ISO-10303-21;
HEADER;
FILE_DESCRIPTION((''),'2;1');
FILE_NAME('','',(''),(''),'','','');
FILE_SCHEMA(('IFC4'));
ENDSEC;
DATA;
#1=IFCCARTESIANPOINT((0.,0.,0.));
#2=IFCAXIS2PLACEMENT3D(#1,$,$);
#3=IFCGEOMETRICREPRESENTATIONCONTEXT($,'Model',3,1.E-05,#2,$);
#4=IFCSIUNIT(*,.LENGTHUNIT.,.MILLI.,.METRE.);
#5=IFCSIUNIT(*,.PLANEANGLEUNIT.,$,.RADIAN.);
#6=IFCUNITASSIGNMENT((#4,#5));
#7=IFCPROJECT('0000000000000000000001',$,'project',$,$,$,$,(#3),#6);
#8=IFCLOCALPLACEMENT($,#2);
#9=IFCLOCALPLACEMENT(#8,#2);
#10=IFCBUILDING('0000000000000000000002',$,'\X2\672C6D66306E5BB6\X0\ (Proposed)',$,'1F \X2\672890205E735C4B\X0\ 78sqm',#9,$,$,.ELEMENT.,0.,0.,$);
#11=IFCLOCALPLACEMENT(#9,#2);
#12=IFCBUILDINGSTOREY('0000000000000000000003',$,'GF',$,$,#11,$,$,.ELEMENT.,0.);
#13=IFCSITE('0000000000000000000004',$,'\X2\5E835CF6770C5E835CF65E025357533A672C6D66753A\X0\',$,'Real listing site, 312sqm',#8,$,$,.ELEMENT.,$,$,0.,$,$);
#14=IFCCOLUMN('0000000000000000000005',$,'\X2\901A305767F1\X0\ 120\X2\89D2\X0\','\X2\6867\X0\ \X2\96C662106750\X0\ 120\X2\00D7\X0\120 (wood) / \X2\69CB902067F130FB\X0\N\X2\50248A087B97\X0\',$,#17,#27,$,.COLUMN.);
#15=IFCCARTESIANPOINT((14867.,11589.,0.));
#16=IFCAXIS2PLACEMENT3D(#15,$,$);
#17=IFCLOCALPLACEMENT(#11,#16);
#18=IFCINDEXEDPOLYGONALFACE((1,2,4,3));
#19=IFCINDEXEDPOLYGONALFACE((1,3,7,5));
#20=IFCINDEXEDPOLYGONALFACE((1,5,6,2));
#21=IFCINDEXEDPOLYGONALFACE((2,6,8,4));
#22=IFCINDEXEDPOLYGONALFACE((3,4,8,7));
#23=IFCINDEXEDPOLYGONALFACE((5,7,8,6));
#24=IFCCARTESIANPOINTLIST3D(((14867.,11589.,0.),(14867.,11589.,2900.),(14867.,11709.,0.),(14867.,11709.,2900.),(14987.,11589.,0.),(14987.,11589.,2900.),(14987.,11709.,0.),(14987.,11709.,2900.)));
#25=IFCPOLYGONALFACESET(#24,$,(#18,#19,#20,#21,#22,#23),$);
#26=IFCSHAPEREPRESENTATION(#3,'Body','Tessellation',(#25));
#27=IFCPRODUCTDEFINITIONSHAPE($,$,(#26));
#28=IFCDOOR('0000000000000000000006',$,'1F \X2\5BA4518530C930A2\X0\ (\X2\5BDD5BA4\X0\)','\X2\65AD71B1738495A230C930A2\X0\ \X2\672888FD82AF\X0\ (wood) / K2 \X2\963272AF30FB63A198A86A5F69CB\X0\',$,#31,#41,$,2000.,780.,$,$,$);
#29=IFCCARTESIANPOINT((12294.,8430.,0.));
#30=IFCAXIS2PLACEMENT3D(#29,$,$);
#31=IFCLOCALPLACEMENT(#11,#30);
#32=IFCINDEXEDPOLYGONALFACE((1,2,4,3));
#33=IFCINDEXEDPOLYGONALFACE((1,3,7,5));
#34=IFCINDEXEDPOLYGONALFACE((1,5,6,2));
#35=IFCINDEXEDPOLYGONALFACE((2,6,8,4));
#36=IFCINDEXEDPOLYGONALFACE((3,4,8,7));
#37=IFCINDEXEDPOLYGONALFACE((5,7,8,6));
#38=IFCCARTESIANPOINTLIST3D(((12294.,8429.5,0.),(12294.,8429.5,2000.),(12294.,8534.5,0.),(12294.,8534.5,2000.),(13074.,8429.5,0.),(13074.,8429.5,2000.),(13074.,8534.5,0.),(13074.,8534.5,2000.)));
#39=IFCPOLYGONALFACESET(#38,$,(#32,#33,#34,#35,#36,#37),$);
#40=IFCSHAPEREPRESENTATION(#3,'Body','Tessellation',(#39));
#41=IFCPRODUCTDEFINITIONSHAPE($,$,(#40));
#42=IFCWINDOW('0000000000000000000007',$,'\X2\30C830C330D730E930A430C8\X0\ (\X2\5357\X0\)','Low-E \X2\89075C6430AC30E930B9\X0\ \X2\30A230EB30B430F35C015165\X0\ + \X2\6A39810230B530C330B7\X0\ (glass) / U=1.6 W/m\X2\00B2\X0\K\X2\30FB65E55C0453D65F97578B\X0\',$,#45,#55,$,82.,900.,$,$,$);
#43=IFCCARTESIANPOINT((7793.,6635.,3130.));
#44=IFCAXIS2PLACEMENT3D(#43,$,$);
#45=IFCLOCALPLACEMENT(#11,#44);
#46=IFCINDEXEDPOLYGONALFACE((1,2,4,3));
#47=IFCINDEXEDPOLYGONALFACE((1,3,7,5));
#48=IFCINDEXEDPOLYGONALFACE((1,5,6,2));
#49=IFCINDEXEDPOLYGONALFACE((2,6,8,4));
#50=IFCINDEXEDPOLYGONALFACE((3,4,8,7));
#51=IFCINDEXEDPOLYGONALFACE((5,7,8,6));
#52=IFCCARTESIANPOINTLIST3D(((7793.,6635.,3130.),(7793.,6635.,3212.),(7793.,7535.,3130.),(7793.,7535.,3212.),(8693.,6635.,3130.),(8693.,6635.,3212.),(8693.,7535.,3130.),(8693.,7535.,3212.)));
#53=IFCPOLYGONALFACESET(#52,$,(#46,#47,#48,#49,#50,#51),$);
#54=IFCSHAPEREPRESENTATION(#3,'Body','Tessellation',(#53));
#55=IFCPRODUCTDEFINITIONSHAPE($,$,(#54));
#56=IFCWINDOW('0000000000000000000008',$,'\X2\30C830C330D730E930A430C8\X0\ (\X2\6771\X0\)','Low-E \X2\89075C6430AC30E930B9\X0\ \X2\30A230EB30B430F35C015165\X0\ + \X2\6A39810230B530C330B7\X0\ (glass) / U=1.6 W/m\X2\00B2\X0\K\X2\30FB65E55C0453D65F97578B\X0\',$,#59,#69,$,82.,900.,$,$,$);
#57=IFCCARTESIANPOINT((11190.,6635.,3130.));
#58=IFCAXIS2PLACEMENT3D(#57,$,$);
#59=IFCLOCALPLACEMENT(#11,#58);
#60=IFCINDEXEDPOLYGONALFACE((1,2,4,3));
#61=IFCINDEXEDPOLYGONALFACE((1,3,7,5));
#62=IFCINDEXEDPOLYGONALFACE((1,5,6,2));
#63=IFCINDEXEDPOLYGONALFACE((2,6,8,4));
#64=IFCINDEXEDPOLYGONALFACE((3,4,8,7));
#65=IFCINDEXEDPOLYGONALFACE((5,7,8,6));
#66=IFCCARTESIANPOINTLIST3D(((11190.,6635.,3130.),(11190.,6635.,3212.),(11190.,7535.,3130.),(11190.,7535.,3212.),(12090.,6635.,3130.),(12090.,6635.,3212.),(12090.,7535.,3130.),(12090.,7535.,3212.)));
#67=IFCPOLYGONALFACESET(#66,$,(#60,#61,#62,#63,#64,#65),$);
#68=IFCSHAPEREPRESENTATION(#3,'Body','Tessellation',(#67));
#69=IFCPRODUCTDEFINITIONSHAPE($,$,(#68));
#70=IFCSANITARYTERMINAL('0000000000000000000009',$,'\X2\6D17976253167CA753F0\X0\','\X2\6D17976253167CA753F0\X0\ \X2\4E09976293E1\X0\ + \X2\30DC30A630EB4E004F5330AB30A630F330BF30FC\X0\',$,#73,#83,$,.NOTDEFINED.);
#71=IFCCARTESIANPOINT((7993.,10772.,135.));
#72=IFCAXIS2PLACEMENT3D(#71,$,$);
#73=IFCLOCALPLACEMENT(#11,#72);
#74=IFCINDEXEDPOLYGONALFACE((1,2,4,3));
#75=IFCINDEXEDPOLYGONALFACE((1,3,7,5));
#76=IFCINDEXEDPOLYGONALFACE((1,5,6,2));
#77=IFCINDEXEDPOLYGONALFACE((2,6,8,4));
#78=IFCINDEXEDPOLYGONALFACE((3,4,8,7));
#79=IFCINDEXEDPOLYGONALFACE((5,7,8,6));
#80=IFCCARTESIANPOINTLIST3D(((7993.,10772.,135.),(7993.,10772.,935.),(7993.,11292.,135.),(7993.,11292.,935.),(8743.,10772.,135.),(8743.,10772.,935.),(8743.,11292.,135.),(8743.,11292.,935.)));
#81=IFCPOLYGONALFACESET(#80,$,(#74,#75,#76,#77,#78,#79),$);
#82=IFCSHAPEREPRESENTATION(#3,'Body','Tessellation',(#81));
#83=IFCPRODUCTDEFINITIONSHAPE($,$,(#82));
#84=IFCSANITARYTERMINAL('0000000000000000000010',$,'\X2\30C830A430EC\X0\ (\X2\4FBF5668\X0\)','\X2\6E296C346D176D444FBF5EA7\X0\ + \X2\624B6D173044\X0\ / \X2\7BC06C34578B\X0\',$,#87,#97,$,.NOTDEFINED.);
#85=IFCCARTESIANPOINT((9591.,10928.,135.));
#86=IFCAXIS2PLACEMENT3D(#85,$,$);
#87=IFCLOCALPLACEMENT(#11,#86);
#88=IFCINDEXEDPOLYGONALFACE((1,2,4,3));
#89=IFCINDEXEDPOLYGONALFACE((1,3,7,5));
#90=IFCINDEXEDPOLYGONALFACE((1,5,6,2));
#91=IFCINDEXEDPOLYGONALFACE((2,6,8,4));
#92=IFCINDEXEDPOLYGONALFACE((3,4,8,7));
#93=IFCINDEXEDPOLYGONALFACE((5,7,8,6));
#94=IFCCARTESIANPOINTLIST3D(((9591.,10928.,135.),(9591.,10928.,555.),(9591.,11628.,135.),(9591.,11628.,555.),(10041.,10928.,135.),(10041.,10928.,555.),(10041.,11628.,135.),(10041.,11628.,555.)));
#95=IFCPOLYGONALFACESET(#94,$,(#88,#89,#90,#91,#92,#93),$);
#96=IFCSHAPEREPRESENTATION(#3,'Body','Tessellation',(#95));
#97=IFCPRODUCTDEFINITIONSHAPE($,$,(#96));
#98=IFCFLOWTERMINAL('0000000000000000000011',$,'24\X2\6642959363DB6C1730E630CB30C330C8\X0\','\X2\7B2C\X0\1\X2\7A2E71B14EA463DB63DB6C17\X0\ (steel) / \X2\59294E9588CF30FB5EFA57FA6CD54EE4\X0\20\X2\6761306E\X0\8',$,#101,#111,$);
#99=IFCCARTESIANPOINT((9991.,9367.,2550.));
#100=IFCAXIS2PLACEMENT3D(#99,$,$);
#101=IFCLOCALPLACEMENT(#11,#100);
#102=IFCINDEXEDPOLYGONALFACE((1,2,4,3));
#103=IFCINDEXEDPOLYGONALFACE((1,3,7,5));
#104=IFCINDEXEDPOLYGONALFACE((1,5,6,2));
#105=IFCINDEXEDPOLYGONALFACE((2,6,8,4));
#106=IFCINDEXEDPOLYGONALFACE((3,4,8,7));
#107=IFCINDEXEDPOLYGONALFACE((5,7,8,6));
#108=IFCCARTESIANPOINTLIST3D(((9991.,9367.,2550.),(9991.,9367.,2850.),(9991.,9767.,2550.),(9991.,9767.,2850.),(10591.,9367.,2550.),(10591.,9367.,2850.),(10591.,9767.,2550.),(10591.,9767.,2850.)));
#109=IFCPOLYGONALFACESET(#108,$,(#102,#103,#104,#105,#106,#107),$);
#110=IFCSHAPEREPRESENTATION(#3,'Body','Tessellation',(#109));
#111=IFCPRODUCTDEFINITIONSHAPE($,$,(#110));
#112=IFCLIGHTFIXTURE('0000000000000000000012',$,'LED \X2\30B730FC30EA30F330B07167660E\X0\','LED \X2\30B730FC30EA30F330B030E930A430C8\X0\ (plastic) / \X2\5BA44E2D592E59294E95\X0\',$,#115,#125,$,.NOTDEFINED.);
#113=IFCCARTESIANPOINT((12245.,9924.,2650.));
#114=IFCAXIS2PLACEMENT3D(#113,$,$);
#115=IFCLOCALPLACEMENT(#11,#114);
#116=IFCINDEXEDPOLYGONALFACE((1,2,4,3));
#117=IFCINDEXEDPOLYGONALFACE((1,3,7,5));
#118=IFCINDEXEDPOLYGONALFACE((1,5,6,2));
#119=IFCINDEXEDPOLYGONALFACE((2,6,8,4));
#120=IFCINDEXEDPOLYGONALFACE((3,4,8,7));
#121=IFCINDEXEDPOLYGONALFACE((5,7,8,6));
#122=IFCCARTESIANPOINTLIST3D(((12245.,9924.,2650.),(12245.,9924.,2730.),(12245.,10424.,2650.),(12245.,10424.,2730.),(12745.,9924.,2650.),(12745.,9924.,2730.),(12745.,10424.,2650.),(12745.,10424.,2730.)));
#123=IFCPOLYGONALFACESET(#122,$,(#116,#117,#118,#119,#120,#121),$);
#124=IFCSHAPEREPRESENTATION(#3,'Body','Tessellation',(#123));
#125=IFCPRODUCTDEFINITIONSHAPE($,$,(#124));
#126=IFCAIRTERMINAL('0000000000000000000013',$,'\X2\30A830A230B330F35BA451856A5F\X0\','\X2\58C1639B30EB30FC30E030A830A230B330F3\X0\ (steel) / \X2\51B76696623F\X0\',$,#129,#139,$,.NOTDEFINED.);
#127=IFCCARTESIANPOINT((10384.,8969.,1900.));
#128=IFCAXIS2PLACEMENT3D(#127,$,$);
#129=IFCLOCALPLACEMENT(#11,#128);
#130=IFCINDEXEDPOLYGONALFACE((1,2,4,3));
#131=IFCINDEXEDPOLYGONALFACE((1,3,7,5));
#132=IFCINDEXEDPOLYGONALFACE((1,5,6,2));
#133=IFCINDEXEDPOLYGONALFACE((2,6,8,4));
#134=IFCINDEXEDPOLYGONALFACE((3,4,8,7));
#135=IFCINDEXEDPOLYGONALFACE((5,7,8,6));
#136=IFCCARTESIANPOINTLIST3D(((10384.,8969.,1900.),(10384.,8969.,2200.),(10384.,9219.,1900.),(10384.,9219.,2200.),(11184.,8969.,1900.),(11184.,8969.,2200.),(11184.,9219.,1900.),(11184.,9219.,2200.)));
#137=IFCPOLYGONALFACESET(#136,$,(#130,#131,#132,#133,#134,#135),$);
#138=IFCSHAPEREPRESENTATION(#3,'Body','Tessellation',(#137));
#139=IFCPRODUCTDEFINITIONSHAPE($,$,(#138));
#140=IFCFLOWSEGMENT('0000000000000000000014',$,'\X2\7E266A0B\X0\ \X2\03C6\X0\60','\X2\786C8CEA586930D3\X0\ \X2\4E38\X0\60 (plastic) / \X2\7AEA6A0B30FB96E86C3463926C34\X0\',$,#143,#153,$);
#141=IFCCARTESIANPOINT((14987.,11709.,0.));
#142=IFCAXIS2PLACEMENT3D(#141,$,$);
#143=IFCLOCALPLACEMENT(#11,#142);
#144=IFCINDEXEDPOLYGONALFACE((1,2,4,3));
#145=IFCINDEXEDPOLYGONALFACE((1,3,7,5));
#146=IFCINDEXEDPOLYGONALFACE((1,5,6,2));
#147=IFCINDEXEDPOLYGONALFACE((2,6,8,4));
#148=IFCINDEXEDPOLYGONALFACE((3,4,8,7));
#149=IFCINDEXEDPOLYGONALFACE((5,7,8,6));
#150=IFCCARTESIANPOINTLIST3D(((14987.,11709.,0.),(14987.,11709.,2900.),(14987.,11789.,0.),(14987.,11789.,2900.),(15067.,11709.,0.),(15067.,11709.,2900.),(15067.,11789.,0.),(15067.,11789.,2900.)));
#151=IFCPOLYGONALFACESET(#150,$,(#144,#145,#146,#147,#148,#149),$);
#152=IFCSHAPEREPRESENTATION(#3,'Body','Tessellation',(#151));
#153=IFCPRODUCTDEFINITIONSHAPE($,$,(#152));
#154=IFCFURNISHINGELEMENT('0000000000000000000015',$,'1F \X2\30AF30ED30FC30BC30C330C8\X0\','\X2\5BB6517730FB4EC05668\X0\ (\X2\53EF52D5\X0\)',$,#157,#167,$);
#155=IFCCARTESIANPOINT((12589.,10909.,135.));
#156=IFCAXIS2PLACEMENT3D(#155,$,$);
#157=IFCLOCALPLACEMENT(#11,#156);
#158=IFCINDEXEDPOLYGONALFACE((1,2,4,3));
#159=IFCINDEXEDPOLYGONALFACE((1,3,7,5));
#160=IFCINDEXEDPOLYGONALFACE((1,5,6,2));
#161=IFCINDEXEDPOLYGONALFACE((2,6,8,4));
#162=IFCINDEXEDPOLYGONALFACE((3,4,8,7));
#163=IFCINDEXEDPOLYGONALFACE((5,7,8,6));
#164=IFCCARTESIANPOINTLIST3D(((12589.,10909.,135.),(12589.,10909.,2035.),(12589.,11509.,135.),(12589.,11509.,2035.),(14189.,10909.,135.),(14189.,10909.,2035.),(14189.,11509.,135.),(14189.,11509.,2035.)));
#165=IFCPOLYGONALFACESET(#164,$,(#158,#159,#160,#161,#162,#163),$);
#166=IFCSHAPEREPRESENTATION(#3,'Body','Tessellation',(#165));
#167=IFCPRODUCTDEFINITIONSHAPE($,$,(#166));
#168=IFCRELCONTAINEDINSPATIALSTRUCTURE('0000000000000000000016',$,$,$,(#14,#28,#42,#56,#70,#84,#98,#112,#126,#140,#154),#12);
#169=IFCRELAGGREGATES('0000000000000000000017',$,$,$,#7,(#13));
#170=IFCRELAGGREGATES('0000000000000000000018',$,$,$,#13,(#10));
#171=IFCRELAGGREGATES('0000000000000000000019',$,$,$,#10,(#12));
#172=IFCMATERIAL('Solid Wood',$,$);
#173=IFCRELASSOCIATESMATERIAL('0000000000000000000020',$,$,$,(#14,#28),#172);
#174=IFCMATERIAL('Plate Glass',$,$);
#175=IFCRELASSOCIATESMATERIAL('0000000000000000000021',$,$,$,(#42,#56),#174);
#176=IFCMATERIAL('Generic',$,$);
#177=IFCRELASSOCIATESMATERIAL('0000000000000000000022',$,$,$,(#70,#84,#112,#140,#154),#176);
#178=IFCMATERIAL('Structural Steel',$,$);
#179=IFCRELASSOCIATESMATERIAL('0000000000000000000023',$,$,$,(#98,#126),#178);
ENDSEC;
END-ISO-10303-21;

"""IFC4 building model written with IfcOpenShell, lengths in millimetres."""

from ifc_helpers import new_model, si_unit, frame, frame_2d, origin, place, context, project, spatial, rectangle, extrude, material, element, save


model = new_model("IFC4")

# Units and contexts
model_context = context("Model", 3, precision=1e-05, world=origin())
ifc_project = project(units=[si_unit("LENGTHUNIT", "METRE", prefix="MILLI"), si_unit("PLANEANGLEUNIT", "RADIAN")], contexts=[model_context])

# Site, building, storey
site_placement = place(None, origin())
site = spatial("IfcSite", under=ifc_project, at=site_placement, Name="広島県広島市南区本浦町", ObjectType="Real listing site, 312sqm", CompositionType="ELEMENT", RefElevation=0.0)
building_placement = place(site_placement, origin())
building = spatial("IfcBuilding", under=site, at=building_placement, Name="本浦の家 (Proposed)", ObjectType="1F 木造平屋 78sqm", CompositionType="ELEMENT", ElevationOfRefHeight=0.0, ElevationOfTerrain=0.0)
storey_placement = place(building_placement, origin())
storey = spatial("IfcBuildingStorey", under=building, at=storey_placement, Name="GF", CompositionType="ELEMENT", Elevation=0.0)

# Column
ifc_material_1 = material(Name="Solid Wood")
column_1_placement = place(storey_placement, frame((14867.0, 11589.0, 0.0)))
element("IfcColumn", 1, at=column_1_placement, inside=storey, material=ifc_material_1, Name="通し柱 120角", Description="桧 集成材 120×120 (wood) / 構造柱・N値計算", PredefinedType="COLUMN", context=model_context, shape_type="SweptSolid", body=[
    extrude(rectangle(XDim=120.0, YDim=120.0, at=frame_2d((60.0, 60.0))), frame((14867.0, 11589.0, 0.0)), (0.0, 0.0, 1.0), 2900.0),
])

# Door
door_placement = place(storey_placement, frame((12294.0, 8430.0, 0.0)))
element("IfcDoor", 2, at=door_placement, inside=storey, material=ifc_material_1, Name="1F 室内ドア (寝室)", Description="断熱玄関ドア 木製芯 (wood) / K2 防犯・採風機構", OverallHeight=2000.0, OverallWidth=780.0, context=model_context, shape_type="SweptSolid", body=[
    extrude(rectangle(XDim=780.0, YDim=105.0, at=frame_2d((390.0, 52.0))), frame((12294.0, 8430.0, 0.0)), (0.0, 0.0, 1.0), 2000.0),
])

# Windows
ifc_material_2 = material(Name="Plate Glass")
window_1_placement = place(storey_placement, frame((7793.0, 6635.0, 3130.0)))
element("IfcWindow", 3, at=window_1_placement, inside=storey, material=ifc_material_2, Name="トップライト (南)", Description="Low-E 複層ガラス アルゴン封入 + 樹脂サッシ (glass) / U=1.6 W/m²K・日射取得型", OverallHeight=82.0, OverallWidth=900.0, context=model_context, shape_type="SweptSolid", body=[
    extrude(rectangle(XDim=900.0, YDim=900.0, at=frame_2d((450.0, 450.0))), frame((7793.0, 6635.0, 3130.0)), (0.0, 0.0, 1.0), 82.0),
])
window_2_placement = place(storey_placement, frame((11190.0, 6635.0, 3130.0)))
element("IfcWindow", 4, at=window_2_placement, inside=storey, material=ifc_material_2, Name="トップライト (東)", Description="Low-E 複層ガラス アルゴン封入 + 樹脂サッシ (glass) / U=1.6 W/m²K・日射取得型", OverallHeight=82.0, OverallWidth=900.0, context=model_context, shape_type="SweptSolid", body=[
    extrude(rectangle(XDim=900.0, YDim=900.0, at=frame_2d((450.0, 450.0))), frame((11190.0, 6635.0, 3130.0)), (0.0, 0.0, 1.0), 82.0),
])

# Sanitary terminals
ifc_material_3 = material(Name="Generic")
sanitary_terminal_1_placement = place(storey_placement, frame((7993.0, 10772.0, 135.0)))
element("IfcSanitaryTerminal", 5, at=sanitary_terminal_1_placement, inside=storey, material=ifc_material_3, Name="洗面化粧台", Description="洗面化粧台 三面鏡 + ボウル一体カウンター", PredefinedType="NOTDEFINED", context=model_context, shape_type="SweptSolid", body=[
    extrude(rectangle(XDim=750.0, YDim=520.0, at=frame_2d((375.0, 260.0))), frame((7993.0, 10772.0, 135.0)), (0.0, 0.0, 1.0), 800.0),
])
sanitary_terminal_2_placement = place(storey_placement, frame((9591.0, 10928.0, 135.0)))
element("IfcSanitaryTerminal", 6, at=sanitary_terminal_2_placement, inside=storey, material=ifc_material_3, Name="トイレ (便器)", Description="温水洗浄便座 + 手洗い / 節水型", PredefinedType="NOTDEFINED", context=model_context, shape_type="SweptSolid", body=[
    extrude(rectangle(XDim=450.0, YDim=700.0, at=frame_2d((225.0, 350.0))), frame((9591.0, 10928.0, 135.0)), (0.0, 0.0, 1.0), 420.0),
])

# Flow terminal
ifc_material_4 = material(Name="Structural Steel")
flow_terminal_placement = place(storey_placement, frame((9991.0, 9367.0, 2550.0)))
element("IfcFlowTerminal", 7, at=flow_terminal_placement, inside=storey, material=ifc_material_4, Name="24時間換気ユニット", Description="第1種熱交換換気 (steel) / 天井裏・建基法令20条の8", context=model_context, shape_type="SweptSolid", body=[
    extrude(rectangle(XDim=600.0, YDim=400.0, at=frame_2d((300.0, 200.0))), frame((9991.0, 9367.0, 2550.0)), (0.0, 0.0, 1.0), 300.0),
])

# Light fixture
light_fixture_placement = place(storey_placement, frame((12245.0, 9924.0, 2650.0)))
element("IfcLightFixture", 8, at=light_fixture_placement, inside=storey, material=ifc_material_3, Name="LED シーリング照明", Description="LED シーリングライト (plastic) / 室中央天井", PredefinedType="NOTDEFINED", context=model_context, shape_type="SweptSolid", body=[
    extrude(rectangle(XDim=500.0, YDim=500.0, at=frame_2d((250.0, 250.0))), frame((12245.0, 9924.0, 2650.0)), (0.0, 0.0, 1.0), 80.0),
])

# Air terminal
air_terminal_placement = place(storey_placement, frame((10384.0, 8969.0, 1900.0)))
element("IfcAirTerminal", 9, at=air_terminal_placement, inside=storey, material=ifc_material_4, Name="エアコン室内機", Description="壁掛ルームエアコン (steel) / 冷暖房", PredefinedType="NOTDEFINED", context=model_context, shape_type="SweptSolid", body=[
    extrude(rectangle(XDim=800.0, YDim=250.0, at=frame_2d((400.0, 125.0))), frame((10384.0, 8969.0, 1900.0)), (0.0, 0.0, 1.0), 300.0),
])

# Flow segment
flow_segment_placement = place(storey_placement, frame((14987.0, 11709.0, 0.0)))
element("IfcFlowSegment", 10, at=flow_segment_placement, inside=storey, material=ifc_material_3, Name="縦樋 φ60", Description="硬質塩ビ 丸60 (plastic) / 竪樋・雨水排水", context=model_context, shape_type="SweptSolid", body=[
    extrude(rectangle(XDim=80.0, YDim=80.0, at=frame_2d((40.0, 40.0))), frame((14987.0, 11709.0, 0.0)), (0.0, 0.0, 1.0), 2900.0),
])

# Furnishing element
furnishing_placement = place(storey_placement, frame((12589.0, 10909.0, 135.0)))
element("IfcFurnishingElement", 11, at=furnishing_placement, inside=storey, material=ifc_material_3, Name="1F クローゼット", Description="家具・什器 (可動)", context=model_context, shape_type="SweptSolid", body=[
    extrude(rectangle(XDim=1600.0, YDim=600.0, at=frame_2d((800.0, 300.0))), frame((12589.0, 10909.0, 135.0)), (0.0, 0.0, 1.0), 1900.0),
])

save(model, "model.ifc")
